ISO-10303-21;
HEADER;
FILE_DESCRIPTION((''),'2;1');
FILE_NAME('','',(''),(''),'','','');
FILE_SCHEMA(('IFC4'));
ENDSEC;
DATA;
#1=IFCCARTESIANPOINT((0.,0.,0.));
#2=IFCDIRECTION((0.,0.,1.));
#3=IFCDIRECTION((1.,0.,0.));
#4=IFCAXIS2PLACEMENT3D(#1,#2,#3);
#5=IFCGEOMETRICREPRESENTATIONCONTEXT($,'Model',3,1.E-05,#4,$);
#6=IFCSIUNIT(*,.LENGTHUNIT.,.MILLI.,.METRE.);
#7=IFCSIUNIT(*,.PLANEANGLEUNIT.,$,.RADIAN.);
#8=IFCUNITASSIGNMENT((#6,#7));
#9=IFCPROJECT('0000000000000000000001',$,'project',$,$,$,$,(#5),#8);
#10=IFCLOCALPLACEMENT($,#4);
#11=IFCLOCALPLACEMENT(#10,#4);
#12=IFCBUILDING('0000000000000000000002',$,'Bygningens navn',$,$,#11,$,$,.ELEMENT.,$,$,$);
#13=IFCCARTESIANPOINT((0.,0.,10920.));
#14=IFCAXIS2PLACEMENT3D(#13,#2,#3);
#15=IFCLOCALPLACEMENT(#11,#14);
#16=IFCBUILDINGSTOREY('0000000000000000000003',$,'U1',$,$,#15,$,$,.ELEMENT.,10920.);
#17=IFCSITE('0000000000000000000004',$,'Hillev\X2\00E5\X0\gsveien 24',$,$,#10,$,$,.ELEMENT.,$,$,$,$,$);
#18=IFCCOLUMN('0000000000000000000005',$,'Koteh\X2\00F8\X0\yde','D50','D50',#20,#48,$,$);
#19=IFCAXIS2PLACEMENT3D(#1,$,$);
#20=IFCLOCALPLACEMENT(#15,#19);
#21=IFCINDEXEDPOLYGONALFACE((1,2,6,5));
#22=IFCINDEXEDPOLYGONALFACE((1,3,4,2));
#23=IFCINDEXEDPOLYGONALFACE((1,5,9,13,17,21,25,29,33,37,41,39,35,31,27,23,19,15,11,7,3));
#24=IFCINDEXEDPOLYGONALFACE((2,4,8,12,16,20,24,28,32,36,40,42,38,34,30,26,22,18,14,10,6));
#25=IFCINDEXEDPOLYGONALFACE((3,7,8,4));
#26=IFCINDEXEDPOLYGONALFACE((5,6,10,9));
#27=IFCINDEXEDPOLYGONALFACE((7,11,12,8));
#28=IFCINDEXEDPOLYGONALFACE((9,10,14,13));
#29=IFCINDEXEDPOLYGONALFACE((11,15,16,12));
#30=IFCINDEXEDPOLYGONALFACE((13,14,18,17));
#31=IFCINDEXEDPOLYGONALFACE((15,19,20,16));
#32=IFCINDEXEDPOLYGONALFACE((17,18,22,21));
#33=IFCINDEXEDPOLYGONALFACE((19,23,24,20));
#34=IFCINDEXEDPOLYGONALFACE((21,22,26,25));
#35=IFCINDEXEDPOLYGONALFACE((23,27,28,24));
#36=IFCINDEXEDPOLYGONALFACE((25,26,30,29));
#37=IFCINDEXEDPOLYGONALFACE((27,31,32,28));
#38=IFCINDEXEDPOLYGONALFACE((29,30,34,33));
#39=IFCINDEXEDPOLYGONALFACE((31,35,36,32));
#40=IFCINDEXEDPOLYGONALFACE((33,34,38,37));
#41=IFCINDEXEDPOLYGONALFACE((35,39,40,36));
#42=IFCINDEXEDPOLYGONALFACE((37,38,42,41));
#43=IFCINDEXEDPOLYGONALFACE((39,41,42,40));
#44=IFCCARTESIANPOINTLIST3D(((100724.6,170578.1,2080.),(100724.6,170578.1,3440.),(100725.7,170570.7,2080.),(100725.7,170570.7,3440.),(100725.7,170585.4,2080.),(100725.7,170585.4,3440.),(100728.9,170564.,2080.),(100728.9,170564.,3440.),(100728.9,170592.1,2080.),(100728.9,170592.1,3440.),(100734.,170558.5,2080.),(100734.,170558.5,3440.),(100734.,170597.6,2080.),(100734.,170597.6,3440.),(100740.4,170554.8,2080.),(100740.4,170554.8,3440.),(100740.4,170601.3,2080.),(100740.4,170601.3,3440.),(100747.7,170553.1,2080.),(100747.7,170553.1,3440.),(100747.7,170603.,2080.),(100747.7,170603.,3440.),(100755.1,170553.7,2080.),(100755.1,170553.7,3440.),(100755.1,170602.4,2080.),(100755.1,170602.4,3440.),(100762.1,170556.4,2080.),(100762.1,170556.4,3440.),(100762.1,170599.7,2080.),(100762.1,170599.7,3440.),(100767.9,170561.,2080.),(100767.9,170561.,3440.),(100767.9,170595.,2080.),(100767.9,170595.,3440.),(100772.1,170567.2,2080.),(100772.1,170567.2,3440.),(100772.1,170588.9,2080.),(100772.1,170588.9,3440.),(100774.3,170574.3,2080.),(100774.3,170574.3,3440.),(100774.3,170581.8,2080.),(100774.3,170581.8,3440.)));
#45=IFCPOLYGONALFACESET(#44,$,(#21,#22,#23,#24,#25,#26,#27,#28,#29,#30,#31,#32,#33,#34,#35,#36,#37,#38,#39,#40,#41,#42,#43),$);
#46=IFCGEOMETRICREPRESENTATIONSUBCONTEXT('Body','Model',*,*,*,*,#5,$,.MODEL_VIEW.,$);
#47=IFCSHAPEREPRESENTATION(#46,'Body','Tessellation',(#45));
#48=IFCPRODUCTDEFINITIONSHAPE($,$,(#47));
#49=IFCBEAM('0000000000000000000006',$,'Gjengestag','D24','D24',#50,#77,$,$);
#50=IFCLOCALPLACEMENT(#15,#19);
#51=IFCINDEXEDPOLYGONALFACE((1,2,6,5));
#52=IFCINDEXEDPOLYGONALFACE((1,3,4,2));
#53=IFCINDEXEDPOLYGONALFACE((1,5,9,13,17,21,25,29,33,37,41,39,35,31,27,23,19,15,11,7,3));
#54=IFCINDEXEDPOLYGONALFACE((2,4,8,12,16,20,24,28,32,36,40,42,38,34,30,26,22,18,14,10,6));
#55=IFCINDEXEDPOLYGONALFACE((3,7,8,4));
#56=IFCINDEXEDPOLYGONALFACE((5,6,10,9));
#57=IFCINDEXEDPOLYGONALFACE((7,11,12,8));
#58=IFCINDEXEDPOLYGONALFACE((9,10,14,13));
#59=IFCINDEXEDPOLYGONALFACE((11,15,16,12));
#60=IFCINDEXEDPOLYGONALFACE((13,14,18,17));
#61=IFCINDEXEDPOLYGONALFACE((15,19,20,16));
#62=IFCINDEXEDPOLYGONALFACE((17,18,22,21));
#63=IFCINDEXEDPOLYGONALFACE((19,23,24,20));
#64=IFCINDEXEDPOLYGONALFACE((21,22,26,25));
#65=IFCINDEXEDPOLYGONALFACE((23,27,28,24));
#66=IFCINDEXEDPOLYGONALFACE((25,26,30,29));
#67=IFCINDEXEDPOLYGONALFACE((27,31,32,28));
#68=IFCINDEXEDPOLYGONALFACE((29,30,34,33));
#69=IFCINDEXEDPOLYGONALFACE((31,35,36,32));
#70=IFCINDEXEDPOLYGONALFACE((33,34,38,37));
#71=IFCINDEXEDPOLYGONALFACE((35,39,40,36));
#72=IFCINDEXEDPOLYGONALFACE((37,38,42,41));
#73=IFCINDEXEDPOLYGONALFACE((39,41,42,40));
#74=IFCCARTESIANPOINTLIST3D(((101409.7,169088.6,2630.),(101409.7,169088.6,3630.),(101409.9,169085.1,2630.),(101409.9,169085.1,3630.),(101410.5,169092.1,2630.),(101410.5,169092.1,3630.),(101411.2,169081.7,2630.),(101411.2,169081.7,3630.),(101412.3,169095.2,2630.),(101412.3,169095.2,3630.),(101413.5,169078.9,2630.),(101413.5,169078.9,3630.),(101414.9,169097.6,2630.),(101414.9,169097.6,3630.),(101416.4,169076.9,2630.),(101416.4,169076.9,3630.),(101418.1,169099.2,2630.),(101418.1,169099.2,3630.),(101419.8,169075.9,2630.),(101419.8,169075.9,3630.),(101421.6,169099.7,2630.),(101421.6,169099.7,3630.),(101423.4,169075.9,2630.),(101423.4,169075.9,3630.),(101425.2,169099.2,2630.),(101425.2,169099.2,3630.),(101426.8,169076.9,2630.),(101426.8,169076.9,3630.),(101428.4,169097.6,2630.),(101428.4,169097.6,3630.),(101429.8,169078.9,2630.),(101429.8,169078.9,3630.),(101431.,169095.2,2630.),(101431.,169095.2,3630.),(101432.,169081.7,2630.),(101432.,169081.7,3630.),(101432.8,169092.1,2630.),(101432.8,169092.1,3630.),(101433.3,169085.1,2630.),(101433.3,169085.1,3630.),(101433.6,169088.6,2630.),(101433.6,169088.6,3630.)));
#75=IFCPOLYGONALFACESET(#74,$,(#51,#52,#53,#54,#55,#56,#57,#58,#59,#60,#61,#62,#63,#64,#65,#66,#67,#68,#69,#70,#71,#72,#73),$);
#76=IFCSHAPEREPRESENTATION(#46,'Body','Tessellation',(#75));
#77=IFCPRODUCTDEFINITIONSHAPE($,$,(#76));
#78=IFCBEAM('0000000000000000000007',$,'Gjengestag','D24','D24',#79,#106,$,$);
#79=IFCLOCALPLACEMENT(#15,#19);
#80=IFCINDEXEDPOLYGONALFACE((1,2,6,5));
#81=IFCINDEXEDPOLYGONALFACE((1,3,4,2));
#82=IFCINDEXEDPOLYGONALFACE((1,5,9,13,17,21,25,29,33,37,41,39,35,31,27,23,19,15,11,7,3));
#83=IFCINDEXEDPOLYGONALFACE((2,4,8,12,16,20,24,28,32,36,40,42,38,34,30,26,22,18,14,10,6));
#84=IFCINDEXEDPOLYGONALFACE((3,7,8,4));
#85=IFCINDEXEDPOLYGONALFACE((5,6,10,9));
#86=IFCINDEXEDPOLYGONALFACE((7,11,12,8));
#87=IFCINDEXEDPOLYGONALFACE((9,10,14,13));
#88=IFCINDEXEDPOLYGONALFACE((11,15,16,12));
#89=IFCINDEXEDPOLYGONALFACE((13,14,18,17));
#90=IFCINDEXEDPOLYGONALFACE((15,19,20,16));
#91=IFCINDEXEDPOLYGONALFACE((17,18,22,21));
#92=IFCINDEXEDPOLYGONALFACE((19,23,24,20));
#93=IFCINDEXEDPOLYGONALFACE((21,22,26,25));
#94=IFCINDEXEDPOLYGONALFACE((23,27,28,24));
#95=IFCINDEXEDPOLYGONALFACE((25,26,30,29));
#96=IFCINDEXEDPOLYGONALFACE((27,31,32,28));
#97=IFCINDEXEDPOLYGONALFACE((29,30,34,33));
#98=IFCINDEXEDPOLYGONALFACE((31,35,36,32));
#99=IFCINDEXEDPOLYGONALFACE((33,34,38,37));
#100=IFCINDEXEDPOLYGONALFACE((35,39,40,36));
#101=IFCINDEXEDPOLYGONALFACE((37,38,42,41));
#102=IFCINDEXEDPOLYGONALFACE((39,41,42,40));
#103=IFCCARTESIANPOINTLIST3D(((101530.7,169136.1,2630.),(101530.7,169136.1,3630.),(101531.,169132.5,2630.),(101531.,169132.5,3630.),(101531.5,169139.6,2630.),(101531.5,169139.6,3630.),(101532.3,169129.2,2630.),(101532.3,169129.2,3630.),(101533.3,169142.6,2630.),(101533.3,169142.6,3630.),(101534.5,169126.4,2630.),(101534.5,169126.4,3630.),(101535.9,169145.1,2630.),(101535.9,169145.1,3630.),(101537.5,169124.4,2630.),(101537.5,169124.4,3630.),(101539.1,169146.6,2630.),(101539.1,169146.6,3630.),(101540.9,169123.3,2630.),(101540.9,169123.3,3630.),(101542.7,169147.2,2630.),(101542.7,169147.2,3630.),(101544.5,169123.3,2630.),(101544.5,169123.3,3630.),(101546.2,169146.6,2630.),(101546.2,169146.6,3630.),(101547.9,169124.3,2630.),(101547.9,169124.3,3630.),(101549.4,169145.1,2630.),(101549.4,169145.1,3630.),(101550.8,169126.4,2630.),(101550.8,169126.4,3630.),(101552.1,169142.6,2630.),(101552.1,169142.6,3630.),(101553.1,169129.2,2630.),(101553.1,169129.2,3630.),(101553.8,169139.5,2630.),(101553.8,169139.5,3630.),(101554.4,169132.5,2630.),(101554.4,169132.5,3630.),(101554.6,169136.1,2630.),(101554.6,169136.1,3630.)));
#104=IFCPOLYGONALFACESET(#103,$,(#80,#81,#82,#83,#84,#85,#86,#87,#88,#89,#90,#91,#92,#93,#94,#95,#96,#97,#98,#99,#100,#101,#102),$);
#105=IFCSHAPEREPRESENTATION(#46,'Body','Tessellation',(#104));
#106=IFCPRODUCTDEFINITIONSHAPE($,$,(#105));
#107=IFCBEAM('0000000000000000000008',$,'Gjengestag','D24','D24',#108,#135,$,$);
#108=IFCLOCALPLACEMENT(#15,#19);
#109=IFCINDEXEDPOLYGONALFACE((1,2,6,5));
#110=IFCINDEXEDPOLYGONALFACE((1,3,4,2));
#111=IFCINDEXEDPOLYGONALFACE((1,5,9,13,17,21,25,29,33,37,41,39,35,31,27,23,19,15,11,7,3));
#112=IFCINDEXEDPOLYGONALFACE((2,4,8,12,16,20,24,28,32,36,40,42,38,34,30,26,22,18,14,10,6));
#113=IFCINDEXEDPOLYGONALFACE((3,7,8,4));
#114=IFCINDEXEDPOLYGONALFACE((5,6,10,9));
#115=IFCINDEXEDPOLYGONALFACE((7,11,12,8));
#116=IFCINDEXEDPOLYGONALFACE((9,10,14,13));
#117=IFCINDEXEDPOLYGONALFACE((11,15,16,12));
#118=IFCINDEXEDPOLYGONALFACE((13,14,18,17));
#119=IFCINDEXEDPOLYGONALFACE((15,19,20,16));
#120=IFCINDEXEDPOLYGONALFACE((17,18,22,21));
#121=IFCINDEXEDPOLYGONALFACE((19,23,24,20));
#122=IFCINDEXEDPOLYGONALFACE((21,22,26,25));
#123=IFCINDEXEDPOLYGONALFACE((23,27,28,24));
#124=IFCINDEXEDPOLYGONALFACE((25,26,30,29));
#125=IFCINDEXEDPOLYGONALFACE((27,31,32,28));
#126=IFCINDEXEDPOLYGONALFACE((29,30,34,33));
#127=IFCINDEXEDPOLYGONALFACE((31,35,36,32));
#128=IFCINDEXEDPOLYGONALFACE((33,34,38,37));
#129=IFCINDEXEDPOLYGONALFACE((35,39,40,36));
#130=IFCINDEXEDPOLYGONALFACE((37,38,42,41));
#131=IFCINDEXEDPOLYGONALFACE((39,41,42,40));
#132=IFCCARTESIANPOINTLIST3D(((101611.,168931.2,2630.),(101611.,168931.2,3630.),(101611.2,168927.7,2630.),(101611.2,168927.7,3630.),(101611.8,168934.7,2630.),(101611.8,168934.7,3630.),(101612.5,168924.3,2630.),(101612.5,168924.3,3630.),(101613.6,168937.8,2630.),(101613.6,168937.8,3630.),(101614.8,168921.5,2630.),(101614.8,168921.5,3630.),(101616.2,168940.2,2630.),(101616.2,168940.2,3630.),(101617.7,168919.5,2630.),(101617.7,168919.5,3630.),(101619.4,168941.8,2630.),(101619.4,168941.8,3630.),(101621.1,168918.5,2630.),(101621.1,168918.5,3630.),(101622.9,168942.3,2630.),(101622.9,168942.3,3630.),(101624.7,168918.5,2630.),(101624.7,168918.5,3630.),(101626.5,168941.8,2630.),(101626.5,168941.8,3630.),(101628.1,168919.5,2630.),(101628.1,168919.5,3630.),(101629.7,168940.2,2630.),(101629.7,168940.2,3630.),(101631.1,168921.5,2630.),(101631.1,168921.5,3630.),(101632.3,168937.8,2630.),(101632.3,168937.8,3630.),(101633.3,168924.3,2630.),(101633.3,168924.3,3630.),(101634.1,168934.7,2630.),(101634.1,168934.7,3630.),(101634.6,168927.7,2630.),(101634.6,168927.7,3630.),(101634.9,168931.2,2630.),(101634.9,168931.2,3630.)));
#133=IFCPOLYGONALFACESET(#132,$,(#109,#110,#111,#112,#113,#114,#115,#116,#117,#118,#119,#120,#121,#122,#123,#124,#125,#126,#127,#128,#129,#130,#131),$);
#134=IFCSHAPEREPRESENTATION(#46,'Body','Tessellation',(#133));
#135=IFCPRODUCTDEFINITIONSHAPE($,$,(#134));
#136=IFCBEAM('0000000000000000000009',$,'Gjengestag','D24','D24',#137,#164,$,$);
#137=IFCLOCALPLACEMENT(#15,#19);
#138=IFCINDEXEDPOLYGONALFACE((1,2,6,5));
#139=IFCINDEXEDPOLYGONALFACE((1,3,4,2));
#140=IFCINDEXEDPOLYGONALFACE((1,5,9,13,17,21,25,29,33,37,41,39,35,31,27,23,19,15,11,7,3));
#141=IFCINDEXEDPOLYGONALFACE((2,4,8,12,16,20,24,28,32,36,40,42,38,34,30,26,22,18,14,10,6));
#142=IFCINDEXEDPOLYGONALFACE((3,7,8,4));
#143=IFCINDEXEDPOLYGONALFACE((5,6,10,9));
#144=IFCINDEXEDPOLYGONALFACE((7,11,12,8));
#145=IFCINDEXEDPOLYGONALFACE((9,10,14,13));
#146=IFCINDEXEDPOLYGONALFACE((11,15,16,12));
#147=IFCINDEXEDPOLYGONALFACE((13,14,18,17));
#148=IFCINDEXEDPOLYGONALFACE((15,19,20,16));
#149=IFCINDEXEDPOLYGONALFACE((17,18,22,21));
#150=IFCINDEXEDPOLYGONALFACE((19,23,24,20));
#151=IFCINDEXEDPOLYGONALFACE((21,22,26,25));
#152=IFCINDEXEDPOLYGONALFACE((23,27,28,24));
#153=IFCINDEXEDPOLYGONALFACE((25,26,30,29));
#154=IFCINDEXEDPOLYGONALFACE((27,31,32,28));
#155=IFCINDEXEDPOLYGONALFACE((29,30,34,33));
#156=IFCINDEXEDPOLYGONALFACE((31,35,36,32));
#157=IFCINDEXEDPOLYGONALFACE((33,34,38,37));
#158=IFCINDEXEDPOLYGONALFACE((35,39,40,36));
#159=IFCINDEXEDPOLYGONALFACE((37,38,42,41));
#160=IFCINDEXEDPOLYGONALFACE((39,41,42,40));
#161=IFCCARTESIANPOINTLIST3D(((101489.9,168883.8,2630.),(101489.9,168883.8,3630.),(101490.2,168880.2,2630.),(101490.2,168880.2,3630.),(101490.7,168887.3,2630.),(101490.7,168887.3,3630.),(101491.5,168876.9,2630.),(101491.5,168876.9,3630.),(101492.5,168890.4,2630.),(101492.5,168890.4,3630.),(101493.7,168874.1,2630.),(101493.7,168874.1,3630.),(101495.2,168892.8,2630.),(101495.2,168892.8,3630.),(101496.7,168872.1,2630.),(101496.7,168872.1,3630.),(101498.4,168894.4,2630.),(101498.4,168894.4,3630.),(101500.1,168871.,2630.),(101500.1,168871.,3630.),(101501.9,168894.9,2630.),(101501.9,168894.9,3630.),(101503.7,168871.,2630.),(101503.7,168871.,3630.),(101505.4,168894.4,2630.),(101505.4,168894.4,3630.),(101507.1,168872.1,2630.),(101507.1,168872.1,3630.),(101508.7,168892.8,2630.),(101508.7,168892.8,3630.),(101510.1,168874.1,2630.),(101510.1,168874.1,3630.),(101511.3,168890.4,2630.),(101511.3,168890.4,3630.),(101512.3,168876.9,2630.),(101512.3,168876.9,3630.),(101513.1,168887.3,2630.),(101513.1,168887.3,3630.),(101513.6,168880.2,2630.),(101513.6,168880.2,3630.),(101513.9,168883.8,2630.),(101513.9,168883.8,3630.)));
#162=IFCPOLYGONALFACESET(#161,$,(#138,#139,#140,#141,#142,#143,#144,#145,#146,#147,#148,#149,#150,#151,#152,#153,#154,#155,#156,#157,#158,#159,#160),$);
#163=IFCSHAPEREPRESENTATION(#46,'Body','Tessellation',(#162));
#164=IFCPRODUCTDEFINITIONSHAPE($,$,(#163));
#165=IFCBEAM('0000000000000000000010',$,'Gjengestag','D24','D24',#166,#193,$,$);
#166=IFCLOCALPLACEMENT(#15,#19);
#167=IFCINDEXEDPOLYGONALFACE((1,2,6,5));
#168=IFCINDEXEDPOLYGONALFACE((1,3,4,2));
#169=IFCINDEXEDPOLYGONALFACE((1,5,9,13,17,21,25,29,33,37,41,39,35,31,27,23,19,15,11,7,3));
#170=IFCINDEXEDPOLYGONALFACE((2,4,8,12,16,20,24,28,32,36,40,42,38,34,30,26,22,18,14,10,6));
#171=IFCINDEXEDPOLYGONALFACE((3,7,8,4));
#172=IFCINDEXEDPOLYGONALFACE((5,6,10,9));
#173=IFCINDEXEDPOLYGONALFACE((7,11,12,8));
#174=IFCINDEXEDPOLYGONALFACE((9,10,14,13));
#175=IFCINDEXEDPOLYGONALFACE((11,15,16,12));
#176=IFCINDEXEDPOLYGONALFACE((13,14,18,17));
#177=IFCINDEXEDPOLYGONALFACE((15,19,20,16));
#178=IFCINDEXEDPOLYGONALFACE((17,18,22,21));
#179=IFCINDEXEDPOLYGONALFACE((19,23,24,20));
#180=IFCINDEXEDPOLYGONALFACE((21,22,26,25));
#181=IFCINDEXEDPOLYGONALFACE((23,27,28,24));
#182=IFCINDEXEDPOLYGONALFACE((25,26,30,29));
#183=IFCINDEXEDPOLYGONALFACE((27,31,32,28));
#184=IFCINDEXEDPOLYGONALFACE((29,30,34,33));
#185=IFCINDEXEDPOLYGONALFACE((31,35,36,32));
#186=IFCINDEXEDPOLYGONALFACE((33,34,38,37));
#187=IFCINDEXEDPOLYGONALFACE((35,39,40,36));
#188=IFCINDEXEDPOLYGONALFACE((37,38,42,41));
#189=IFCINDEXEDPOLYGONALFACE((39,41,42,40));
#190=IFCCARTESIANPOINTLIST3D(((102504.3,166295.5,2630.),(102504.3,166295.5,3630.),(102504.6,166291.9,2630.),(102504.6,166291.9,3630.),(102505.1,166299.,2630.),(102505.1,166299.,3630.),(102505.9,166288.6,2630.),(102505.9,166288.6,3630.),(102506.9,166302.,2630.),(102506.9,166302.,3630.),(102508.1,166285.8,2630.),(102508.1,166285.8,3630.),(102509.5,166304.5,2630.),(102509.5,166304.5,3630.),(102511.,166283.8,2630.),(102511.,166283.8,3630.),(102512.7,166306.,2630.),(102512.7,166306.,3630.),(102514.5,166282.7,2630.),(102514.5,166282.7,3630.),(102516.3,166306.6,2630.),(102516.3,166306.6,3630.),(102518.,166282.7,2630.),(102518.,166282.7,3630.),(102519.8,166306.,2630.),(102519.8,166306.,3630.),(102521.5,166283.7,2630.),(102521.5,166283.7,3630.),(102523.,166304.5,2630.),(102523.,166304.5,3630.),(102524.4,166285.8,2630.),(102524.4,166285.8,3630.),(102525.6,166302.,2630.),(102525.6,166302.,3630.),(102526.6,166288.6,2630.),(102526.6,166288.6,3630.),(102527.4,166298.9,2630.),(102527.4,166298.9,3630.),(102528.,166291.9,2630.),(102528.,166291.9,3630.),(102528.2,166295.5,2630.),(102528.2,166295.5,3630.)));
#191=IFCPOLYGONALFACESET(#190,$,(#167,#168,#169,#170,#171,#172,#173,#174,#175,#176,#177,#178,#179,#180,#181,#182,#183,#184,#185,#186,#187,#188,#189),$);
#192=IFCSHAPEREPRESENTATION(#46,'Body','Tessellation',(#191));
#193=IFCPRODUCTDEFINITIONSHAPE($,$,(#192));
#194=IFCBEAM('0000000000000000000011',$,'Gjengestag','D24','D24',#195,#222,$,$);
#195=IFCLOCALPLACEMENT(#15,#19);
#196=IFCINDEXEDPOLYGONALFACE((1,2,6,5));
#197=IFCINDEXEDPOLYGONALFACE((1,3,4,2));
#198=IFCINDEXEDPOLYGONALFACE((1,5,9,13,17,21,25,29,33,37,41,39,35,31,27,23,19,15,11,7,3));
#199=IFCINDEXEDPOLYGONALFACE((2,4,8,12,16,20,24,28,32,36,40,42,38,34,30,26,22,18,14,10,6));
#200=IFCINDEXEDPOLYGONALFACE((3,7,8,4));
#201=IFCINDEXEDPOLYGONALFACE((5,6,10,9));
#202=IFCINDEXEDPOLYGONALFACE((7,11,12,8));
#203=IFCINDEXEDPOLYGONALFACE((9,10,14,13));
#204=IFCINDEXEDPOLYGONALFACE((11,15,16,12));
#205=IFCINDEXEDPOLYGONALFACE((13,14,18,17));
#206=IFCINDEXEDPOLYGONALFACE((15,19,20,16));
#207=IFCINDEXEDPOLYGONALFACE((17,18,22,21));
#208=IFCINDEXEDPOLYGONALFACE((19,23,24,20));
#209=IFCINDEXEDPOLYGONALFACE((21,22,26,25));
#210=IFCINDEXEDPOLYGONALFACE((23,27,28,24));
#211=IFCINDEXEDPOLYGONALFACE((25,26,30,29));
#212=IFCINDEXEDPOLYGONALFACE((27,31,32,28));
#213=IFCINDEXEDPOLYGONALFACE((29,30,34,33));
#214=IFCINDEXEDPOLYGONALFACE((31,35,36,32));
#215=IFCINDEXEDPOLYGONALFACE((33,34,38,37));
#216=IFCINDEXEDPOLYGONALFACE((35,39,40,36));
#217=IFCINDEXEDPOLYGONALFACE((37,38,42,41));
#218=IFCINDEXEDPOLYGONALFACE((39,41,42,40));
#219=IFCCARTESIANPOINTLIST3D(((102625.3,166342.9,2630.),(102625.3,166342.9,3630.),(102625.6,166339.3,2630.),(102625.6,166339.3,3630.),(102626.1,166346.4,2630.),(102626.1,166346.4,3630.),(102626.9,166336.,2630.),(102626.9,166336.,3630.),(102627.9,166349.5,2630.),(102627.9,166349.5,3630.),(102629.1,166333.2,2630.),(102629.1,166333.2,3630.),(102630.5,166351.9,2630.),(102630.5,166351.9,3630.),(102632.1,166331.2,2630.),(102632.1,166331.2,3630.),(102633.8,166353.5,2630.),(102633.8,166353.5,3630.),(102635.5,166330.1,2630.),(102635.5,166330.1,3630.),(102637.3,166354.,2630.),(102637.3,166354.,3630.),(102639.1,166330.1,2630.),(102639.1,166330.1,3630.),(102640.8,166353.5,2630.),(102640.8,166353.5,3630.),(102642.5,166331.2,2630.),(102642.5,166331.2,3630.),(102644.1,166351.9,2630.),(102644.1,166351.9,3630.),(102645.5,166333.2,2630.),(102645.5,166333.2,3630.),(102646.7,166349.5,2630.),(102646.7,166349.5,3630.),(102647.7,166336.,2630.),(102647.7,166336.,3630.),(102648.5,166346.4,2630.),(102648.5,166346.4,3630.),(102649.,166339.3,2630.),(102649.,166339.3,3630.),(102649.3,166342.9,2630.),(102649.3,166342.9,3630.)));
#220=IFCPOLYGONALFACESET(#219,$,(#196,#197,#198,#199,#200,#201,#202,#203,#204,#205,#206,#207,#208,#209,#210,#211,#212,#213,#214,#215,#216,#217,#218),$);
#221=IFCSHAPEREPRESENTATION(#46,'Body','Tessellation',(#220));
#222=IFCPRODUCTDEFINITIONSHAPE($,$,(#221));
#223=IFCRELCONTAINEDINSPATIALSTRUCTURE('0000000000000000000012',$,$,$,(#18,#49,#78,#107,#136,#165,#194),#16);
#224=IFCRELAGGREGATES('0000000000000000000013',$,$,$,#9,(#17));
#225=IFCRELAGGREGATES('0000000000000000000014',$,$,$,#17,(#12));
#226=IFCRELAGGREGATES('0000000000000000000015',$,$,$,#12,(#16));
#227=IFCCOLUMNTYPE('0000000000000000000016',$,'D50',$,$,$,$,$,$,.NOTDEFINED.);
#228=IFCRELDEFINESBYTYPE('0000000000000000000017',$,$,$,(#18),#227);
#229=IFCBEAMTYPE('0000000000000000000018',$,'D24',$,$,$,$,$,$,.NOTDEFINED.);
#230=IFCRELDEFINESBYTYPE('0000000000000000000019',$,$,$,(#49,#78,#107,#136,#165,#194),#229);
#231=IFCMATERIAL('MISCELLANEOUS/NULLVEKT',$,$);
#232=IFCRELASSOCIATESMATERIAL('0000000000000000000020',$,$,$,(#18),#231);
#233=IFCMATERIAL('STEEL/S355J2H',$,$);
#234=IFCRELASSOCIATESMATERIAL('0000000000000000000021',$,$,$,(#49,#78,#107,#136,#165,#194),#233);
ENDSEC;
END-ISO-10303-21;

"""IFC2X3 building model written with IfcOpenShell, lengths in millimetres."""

from ifc_helpers import new_model, si_unit, frame, frame_2d, origin_with_axes, place, context, subcontext, project, spatial, circle, extrude, material, type_object, element, save


model = new_model("IFC2X3")

# Units and contexts
model_context = context("Model", 3, precision=1e-05, world=origin_with_axes())
body_context = subcontext(model_context, "Body", "Model", "MODEL_VIEW")
ifc_project = project(units=[si_unit("LENGTHUNIT", "METRE", prefix="MILLI"), si_unit("PLANEANGLEUNIT", "RADIAN")], contexts=[model_context])

# Site, building, storey
site_placement = place(None, origin_with_axes())
site = spatial("IfcSite", under=ifc_project, at=site_placement, Name="Hillevågsveien 24", CompositionType="ELEMENT")
building_placement = place(site_placement, origin_with_axes())
building = spatial("IfcBuilding", under=site, at=building_placement, Name="Bygningens navn", CompositionType="ELEMENT")
storey_placement = place(building_placement, frame((0.0, 0.0, 10920.0), z_axis=(0.0, 0.0, 1.0), x_axis=(1.0, 0.0, 0.0)))
storey = spatial("IfcBuildingStorey", under=building, at=storey_placement, Name="U1", CompositionType="ELEMENT", Elevation=10920.0)

# Column
ifc_material_1 = material(Name="MISCELLANEOUS/NULLVEKT")
column_type = type_object("IfcColumnType", Name="D50", PredefinedType="NOTDEFINED")
column_placement = place(storey_placement, frame((100749.6, 170578.0, 2080.0), z_axis=(0.0, 0.0, 1.0), x_axis=(0.931056, 0.364877, 0.0)))
element("IfcColumn", 1, at=column_placement, inside=storey, type_object=column_type, material=ifc_material_1, Name="Kotehøyde", Description="D50", ObjectType="D50", context=body_context, shape_type="SweptSolid", body=[
    extrude(circle(Radius=25.0, at=frame_2d((0.0, 0.0), x_axis=(1.0, 0.0))), frame((0.0, 0.0, 1360.0), z_axis=(0.0, 0.0, -1.0), x_axis=(0.0, 1.0, 0.0)), (0.0, 0.0, 1.0), 1360.0),
])

# Beams
ifc_material_2 = material(Name="STEEL/S355J2H")
beam_type_1 = type_object("IfcBeamType", Name="D24", PredefinedType="NOTDEFINED")
for number, where, z_axis, x_axis, name in (
    (2, (101421.6, 169087.7, 3630.0), (-0.364877, 0.931056, 0.0), (0.0, 0.0, -1.0), "Gjengestag"),
    (3, (101542.7, 169135.2, 3630.0), (-0.364877, 0.931056, 0.0), (0.0, 0.0, -1.0), "Gjengestag"),
    (4, (101622.9, 168930.3, 3630.0), (-0.364877, 0.931056, 0.0), (0.0, 0.0, -1.0), "Gjengestag"),
    (5, (101501.9, 168882.9, 3630.0), (-0.364877, 0.931056, 0.0), (0.0, 0.0, -1.0), "Gjengestag"),
    (6, (102516.3, 166294.6, 3630.0), (-0.364877, 0.931056, 0.0), (0.0, 0.0, -1.0), "Gjengestag"),
    (7, (102637.3, 166342.0, 3630.0), (-0.364877, 0.931056, 0.0), (0.0, 0.0, -1.0), "Gjengestag"),
):
    element("IfcBeam", number, at=place(storey_placement, frame(where, z_axis=z_axis, x_axis=x_axis)), inside=storey, type_object=beam_type_1, material=ifc_material_2, Name=name, Description="D24", ObjectType="D24", context=body_context, shape_type="SweptSolid", body=[
        extrude(circle(Radius=12.0, at=frame_2d((0.0, 0.0), x_axis=(1.0, 0.0))), frame((1000.0, 0.0, 0.0), z_axis=(-1.0, 0.0, 0.0), x_axis=(0.0, -1.0, 0.0)), (0.0, 0.0, 1.0), 1000.0),
    ])

save(model, "model.ifc")
